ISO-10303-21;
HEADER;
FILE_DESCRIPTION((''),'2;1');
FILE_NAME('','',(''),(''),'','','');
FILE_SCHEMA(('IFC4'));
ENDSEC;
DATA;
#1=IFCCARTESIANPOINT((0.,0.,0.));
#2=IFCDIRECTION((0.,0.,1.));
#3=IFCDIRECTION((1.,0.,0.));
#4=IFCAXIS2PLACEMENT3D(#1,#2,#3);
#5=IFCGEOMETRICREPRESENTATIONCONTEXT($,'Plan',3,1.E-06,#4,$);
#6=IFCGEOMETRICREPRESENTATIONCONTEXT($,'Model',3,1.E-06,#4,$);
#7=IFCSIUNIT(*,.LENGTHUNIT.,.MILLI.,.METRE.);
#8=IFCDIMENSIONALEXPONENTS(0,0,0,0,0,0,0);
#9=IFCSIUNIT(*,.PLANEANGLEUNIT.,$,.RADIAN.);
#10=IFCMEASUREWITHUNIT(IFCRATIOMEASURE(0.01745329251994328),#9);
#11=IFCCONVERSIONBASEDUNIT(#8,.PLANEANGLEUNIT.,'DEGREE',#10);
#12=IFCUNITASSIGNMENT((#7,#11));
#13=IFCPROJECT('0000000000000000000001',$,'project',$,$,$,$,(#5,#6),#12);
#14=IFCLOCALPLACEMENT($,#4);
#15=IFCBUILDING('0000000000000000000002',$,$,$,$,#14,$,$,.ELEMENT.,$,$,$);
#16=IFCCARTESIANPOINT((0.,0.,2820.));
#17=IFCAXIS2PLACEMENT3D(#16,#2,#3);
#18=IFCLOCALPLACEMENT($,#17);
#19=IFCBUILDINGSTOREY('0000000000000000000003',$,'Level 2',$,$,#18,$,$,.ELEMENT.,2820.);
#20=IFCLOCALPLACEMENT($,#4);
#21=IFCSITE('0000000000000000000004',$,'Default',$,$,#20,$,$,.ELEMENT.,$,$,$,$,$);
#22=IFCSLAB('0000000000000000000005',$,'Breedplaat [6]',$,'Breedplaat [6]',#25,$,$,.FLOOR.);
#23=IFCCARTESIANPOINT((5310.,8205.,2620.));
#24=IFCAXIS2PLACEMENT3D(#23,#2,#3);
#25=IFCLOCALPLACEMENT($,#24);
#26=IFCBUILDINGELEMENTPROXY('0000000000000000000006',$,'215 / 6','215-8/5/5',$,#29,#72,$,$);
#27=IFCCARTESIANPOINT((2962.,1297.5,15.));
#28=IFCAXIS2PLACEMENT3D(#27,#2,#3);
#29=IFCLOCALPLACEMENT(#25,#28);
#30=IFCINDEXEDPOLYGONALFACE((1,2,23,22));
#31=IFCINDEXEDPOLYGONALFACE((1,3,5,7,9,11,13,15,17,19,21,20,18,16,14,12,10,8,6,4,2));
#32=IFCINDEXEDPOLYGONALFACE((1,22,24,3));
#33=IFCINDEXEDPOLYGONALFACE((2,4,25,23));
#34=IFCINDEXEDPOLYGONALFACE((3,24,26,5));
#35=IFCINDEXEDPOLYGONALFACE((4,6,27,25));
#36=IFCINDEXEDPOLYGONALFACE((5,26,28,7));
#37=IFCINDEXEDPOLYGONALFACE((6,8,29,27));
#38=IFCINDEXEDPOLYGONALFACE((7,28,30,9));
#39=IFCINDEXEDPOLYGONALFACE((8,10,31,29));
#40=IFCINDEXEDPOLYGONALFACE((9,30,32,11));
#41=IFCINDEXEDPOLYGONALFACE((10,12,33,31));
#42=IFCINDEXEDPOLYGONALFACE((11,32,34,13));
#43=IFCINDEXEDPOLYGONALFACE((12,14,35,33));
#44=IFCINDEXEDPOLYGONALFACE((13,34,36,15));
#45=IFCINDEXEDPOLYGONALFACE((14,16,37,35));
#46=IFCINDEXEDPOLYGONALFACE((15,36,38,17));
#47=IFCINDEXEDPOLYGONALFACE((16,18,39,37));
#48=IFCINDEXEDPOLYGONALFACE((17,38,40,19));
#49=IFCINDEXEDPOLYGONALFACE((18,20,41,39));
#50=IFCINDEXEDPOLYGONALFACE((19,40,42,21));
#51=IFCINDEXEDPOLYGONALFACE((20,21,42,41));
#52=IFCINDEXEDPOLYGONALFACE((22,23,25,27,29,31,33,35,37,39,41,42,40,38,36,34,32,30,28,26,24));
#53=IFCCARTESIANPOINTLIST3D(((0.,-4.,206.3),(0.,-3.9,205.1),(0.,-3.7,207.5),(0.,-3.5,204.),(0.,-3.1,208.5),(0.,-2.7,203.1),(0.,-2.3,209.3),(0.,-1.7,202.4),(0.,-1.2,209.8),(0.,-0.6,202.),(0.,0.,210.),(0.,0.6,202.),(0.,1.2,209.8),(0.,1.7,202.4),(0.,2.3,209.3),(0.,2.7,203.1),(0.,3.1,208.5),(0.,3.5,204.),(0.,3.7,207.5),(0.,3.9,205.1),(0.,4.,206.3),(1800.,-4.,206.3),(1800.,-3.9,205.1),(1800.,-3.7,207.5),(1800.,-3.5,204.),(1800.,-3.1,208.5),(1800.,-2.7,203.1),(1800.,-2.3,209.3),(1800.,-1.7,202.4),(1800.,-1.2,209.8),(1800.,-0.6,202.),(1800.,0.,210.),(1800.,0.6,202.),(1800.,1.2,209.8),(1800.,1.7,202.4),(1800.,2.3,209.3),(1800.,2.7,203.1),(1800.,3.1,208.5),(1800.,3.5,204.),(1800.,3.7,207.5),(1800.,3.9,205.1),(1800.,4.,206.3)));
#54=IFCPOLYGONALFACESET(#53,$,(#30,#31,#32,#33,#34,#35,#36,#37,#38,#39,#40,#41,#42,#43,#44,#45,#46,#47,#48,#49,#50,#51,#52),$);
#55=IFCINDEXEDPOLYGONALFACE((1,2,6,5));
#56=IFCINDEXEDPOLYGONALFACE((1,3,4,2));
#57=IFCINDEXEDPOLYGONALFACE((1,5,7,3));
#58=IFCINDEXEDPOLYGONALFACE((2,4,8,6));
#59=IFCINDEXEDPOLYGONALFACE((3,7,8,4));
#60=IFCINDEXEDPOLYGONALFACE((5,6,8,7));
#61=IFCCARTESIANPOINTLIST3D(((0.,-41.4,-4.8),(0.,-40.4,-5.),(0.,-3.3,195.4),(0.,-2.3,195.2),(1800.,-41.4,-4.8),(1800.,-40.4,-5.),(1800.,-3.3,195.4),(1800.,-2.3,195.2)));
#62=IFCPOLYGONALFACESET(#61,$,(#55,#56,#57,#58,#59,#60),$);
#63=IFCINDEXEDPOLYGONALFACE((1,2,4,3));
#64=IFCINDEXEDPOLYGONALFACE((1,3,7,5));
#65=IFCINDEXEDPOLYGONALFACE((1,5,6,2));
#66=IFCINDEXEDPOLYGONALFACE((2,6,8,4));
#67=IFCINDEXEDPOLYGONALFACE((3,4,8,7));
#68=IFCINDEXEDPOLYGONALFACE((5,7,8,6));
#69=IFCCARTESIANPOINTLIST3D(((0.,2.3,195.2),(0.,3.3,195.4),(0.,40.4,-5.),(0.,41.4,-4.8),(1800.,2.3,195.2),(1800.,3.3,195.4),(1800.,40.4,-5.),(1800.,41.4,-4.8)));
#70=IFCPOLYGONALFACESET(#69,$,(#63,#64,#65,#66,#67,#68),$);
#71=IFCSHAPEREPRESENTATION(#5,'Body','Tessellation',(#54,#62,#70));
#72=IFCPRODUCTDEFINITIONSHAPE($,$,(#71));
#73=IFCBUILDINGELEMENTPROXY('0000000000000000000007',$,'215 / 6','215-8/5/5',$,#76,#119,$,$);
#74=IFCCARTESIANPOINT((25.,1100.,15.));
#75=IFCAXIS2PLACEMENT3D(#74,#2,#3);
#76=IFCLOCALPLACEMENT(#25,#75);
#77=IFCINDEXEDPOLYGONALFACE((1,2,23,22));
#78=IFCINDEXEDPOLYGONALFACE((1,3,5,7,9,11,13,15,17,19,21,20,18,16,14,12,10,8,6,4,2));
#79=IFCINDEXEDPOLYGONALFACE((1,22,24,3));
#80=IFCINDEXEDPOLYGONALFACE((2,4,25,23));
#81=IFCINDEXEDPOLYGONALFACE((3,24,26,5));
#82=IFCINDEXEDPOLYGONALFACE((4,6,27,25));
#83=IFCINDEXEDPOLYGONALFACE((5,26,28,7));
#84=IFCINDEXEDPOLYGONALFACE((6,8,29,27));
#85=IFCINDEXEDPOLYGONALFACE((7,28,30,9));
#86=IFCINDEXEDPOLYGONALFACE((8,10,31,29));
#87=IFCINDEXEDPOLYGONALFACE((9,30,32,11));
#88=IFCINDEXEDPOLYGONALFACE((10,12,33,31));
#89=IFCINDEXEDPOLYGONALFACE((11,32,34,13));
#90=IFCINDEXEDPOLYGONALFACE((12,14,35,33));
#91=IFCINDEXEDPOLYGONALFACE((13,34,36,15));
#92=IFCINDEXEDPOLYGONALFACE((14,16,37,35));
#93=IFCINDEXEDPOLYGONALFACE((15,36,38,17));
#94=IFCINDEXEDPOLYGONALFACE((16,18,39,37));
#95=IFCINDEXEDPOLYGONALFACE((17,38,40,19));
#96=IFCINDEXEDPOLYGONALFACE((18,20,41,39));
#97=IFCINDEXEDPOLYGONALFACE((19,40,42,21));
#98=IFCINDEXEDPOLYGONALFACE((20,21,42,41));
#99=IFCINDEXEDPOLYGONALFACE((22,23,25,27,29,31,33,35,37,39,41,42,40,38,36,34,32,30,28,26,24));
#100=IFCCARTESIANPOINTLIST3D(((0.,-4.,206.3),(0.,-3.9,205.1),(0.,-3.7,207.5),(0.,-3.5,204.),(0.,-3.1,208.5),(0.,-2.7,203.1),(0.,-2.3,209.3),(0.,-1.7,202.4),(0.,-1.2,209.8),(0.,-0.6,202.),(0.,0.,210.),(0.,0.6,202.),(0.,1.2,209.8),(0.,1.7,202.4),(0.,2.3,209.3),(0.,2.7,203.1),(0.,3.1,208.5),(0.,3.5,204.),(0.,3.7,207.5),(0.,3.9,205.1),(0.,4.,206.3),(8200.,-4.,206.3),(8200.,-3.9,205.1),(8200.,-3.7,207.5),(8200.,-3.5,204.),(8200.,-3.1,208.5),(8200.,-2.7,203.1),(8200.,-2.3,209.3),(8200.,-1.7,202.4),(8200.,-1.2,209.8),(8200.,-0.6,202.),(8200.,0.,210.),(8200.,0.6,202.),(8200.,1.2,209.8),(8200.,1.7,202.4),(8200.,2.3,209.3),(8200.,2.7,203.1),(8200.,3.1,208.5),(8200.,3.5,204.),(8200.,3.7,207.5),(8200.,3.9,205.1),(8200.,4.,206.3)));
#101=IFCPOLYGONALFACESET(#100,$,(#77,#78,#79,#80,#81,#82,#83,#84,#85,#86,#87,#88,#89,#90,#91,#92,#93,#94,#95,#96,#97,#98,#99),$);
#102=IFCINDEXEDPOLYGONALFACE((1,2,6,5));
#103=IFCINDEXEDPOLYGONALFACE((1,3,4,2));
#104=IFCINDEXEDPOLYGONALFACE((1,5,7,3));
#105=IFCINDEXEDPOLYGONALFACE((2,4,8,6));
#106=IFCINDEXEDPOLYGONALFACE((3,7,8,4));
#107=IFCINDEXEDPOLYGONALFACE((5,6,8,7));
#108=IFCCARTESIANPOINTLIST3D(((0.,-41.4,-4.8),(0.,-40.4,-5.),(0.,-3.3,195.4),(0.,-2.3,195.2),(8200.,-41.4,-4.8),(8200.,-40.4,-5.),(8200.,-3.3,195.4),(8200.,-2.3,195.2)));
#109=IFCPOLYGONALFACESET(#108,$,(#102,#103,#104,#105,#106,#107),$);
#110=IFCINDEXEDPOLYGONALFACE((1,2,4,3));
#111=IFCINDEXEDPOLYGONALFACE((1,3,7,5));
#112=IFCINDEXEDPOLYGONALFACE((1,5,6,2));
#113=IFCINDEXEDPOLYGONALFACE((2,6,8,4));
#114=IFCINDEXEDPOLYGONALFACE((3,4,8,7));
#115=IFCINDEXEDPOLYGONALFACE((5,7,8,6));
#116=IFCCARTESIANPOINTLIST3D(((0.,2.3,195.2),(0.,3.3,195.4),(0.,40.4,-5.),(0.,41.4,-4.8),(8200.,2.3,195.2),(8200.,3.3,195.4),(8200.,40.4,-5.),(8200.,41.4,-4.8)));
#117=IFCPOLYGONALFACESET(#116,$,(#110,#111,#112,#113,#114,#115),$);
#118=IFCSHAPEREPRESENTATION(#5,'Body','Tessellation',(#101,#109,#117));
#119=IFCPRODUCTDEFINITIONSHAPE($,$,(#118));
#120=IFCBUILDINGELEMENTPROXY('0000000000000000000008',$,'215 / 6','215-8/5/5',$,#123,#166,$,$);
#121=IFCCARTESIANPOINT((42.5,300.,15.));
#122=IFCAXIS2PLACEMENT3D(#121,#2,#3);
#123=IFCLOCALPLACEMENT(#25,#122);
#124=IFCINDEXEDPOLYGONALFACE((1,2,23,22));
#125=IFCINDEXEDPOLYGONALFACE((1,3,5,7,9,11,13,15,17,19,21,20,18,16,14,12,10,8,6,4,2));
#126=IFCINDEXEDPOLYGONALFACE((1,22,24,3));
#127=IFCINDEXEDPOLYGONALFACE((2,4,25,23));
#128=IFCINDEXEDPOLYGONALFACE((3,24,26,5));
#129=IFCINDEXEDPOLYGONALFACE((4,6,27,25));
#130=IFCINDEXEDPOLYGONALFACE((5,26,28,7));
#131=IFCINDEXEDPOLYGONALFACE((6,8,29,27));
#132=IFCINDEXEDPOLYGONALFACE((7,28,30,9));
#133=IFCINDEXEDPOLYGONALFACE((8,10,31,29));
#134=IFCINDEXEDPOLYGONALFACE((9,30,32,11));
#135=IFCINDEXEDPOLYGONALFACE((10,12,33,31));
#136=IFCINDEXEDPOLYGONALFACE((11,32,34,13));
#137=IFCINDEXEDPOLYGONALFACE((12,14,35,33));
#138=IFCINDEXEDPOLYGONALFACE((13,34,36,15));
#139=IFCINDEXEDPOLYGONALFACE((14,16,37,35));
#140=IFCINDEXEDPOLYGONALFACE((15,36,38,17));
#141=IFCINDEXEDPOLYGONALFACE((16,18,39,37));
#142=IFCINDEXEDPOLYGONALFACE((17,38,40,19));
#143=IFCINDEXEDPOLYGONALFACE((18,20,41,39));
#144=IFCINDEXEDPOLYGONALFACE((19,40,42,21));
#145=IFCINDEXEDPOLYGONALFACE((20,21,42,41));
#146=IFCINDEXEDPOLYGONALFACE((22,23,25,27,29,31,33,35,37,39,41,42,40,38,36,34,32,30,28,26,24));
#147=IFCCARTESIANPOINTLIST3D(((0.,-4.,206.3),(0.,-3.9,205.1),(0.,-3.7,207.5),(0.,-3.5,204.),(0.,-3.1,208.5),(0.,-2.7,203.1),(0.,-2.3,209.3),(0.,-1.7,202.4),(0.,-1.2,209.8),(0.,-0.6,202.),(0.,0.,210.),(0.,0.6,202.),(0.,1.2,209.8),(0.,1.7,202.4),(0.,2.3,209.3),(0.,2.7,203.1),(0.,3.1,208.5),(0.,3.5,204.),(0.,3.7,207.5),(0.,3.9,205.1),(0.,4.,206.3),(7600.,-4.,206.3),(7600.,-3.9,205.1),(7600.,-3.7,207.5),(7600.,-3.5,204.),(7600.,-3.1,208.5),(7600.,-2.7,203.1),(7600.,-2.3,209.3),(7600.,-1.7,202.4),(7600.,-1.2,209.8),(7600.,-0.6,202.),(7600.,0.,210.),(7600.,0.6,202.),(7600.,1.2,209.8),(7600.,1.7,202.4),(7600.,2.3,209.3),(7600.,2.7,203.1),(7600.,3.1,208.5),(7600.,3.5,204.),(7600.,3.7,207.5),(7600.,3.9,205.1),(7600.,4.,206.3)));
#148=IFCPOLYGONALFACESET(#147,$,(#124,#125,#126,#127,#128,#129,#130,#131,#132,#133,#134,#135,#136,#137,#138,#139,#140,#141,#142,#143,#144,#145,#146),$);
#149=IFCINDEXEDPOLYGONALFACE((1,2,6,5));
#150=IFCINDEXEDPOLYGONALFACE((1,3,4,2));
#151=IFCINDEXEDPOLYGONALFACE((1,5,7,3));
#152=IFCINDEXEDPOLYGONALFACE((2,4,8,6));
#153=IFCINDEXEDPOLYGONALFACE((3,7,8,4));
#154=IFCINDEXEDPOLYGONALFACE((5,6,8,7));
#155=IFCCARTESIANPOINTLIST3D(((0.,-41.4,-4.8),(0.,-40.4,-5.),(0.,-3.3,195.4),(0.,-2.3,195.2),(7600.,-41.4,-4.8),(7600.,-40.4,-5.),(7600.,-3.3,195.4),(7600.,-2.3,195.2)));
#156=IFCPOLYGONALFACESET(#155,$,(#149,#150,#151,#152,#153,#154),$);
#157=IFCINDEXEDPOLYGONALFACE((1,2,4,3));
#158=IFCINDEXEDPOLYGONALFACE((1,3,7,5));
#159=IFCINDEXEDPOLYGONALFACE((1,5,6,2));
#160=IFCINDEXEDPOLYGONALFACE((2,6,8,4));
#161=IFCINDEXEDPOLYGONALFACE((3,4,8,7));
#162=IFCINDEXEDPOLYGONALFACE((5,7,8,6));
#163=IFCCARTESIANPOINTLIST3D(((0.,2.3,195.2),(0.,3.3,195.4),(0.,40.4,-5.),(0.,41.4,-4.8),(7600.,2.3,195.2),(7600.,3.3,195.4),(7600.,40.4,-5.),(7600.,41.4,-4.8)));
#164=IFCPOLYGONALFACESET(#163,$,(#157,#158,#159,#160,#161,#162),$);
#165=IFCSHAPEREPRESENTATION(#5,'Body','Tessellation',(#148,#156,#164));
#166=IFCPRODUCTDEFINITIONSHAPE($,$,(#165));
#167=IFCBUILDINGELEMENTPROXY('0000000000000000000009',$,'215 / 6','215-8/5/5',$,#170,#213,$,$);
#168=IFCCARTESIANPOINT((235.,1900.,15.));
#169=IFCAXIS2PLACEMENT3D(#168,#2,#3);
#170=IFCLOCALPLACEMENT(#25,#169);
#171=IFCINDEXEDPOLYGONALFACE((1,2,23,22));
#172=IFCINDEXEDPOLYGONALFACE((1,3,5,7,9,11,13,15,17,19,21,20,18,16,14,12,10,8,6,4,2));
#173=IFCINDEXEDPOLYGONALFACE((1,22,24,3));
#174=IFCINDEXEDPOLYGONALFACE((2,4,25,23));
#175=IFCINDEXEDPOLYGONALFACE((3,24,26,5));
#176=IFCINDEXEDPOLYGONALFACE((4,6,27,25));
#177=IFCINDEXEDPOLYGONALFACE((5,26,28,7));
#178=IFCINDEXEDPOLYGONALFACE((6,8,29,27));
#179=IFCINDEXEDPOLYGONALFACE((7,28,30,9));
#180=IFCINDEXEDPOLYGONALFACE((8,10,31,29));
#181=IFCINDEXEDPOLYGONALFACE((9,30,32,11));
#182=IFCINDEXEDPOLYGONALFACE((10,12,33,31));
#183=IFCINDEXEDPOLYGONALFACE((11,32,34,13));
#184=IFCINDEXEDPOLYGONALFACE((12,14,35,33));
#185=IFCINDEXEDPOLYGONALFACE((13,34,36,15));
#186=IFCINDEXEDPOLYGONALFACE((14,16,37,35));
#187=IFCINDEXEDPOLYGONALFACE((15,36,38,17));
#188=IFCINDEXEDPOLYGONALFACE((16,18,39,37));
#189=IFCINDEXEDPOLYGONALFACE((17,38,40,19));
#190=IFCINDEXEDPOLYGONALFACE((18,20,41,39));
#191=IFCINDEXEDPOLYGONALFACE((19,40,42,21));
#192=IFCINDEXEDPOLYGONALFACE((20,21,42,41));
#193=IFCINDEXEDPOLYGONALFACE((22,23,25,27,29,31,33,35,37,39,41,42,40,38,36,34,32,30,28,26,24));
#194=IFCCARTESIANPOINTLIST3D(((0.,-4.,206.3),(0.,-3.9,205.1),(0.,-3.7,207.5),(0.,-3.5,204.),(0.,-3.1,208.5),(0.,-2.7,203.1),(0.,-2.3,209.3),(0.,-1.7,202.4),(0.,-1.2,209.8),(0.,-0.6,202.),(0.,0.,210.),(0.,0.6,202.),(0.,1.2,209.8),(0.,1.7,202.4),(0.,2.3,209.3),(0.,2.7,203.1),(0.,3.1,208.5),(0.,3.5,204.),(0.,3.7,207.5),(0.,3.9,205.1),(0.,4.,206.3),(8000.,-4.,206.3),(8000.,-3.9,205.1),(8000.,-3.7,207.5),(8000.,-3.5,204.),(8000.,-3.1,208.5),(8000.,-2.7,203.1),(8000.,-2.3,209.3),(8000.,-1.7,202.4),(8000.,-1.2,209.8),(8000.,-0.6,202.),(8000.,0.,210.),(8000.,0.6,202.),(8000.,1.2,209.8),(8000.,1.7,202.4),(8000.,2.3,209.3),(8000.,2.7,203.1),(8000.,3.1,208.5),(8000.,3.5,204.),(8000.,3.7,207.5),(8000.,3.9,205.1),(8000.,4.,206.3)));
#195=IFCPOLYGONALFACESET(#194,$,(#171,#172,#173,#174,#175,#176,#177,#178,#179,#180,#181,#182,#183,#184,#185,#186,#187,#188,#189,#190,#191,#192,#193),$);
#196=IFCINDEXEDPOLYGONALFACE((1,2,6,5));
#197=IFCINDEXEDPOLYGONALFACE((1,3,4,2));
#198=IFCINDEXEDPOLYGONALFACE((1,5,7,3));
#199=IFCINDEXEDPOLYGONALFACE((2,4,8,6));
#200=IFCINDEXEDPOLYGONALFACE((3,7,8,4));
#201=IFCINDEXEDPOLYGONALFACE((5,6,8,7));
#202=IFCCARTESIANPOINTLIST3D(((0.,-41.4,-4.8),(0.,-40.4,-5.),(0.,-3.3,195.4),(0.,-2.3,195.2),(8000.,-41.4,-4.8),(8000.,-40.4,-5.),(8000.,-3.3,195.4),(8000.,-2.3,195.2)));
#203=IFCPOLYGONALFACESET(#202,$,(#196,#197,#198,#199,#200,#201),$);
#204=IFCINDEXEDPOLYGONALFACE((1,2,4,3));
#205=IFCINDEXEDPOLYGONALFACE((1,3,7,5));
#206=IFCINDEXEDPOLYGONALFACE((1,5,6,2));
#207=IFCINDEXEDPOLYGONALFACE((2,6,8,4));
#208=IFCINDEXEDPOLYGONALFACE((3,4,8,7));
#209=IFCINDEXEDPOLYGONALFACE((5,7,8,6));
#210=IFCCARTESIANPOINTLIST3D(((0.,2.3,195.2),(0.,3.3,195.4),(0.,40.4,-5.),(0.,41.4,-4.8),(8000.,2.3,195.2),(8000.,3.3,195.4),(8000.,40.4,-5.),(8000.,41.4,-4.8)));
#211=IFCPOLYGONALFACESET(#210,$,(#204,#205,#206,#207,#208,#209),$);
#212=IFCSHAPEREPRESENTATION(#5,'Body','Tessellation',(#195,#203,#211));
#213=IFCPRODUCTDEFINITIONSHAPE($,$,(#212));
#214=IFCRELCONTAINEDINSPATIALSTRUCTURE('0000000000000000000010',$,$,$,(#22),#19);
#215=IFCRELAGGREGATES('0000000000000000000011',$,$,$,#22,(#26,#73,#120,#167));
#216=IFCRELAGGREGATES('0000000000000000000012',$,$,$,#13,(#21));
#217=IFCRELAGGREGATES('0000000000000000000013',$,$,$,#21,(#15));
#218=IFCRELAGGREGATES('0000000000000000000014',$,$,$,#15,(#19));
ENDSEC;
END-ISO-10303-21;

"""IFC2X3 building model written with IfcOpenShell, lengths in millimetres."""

from ifc_helpers import new_model, entity, si_unit, converted_unit, frame, origin_with_axes, origin_2d_with_axis, place, context, project, spatial, rectangle, circle, extrude, element, aggregate, save


model = new_model("IFC2X3")

# Units and contexts
plan_context = context("Plan", 3, precision=1e-06, world=origin_with_axes())
model_context = context("Model", 3, precision=1e-06, world=origin_with_axes())
ifc_project = project(units=[si_unit("LENGTHUNIT", "METRE", prefix="MILLI"), converted_unit("PLANEANGLEUNIT", "DEGREE", entity("IfcRatioMeasure", 0.01745329251994328), si_unit("PLANEANGLEUNIT", "RADIAN"), dimensions=[0, 0, 0, 0, 0, 0, 0])], contexts=[plan_context, model_context])

# Site, building, storey
site_placement = place(None, origin_with_axes())
site = spatial("IfcSite", under=ifc_project, at=site_placement, Name="Default", CompositionType="ELEMENT")
building_placement = place(None, origin_with_axes())
building = spatial("IfcBuilding", under=site, at=building_placement, CompositionType="ELEMENT")
storey_placement = place(None, frame((0.0, 0.0, 2820.0), z_axis=(0.0, 0.0, 1.0), x_axis=(1.0, 0.0, 0.0)))
storey = spatial("IfcBuildingStorey", under=building, at=storey_placement, Name="Level 2", CompositionType="ELEMENT", Elevation=2820.0)

# Slab, building element proxies
slab_1_placement = place(None, frame((5310.0, 8205.0, 2620.0), z_axis=(0.0, 0.0, 1.0), x_axis=(1.0, 0.0, 0.0)))
slab_1 = element("IfcSlab", 1, at=slab_1_placement, inside=storey, Name="Breedplaat [6]", ObjectType="Breedplaat [6]", PredefinedType="FLOOR")
proxy_1_placement = place(slab_1_placement, frame((2962.0, 1297.5, 15.0), z_axis=(0.0, 0.0, 1.0), x_axis=(1.0, 0.0, 0.0)))
proxy_1 = element("IfcBuildingElementProxy", 2, at=proxy_1_placement, Name="215 / 6", Description="215-8/5/5", context=plan_context, shape_type="SweptSolid", body=[
    extrude(circle(Radius=4.0, at=origin_2d_with_axis()), frame((0.0, 0.0, 206.0), z_axis=(1.0, 0.0, 0.0), x_axis=(0.0, 0.0, 1.0)), (0.0, 0.0, 1.0), 1800.0),
    extrude(rectangle(XDim=203.8, YDim=1.0, at=origin_2d_with_axis()), frame((0.0, -21.9, 95.2), z_axis=(1.0, 0.0, 0.0), x_axis=(0.0, 0.187112, 0.982339)), (0.0, 0.0, 1.0), 1800.0),
    extrude(rectangle(XDim=203.8, YDim=1.0, at=origin_2d_with_axis()), frame((0.0, 21.9, 95.2), z_axis=(1.0, 0.0, 0.0), x_axis=(0.0, -0.187112, 0.982339)), (0.0, 0.0, 1.0), 1800.0),
])
proxy_2_placement = place(slab_1_placement, frame((25.0, 1100.0, 15.0), z_axis=(0.0, 0.0, 1.0), x_axis=(1.0, 0.0, 0.0)))
proxy_2 = element("IfcBuildingElementProxy", 3, at=proxy_2_placement, Name="215 / 6", Description="215-8/5/5", context=plan_context, shape_type="SweptSolid", body=[
    extrude(circle(Radius=4.0, at=origin_2d_with_axis()), frame((0.0, 0.0, 206.0), z_axis=(1.0, 0.0, 0.0), x_axis=(0.0, 0.0, 1.0)), (0.0, 0.0, 1.0), 8200.0),
    extrude(rectangle(XDim=203.8, YDim=1.0, at=origin_2d_with_axis()), frame((0.0, -21.9, 95.2), z_axis=(1.0, 0.0, 0.0), x_axis=(0.0, 0.187112, 0.982339)), (0.0, 0.0, 1.0), 8200.0),
    extrude(rectangle(XDim=203.8, YDim=1.0, at=origin_2d_with_axis()), frame((0.0, 21.9, 95.2), z_axis=(1.0, 0.0, 0.0), x_axis=(0.0, -0.187112, 0.982339)), (0.0, 0.0, 1.0), 8200.0),
])
proxy_3_placement = place(slab_1_placement, frame((42.5, 300.0, 15.0), z_axis=(0.0, 0.0, 1.0), x_axis=(1.0, 0.0, 0.0)))
proxy_3 = element("IfcBuildingElementProxy", 4, at=proxy_3_placement, Name="215 / 6", Description="215-8/5/5", context=plan_context, shape_type="SweptSolid", body=[
    extrude(circle(Radius=4.0, at=origin_2d_with_axis()), frame((0.0, 0.0, 206.0), z_axis=(1.0, 0.0, 0.0), x_axis=(0.0, 0.0, 1.0)), (0.0, 0.0, 1.0), 7600.0),
    extrude(rectangle(XDim=203.8, YDim=1.0, at=origin_2d_with_axis()), frame((0.0, -21.9, 95.2), z_axis=(1.0, 0.0, 0.0), x_axis=(0.0, 0.187112, 0.982339)), (0.0, 0.0, 1.0), 7600.0),
    extrude(rectangle(XDim=203.8, YDim=1.0, at=origin_2d_with_axis()), frame((0.0, 21.9, 95.2), z_axis=(1.0, 0.0, 0.0), x_axis=(0.0, -0.187112, 0.982339)), (0.0, 0.0, 1.0), 7600.0),
])
proxy_4_placement = place(slab_1_placement, frame((235.0, 1900.0, 15.0), z_axis=(0.0, 0.0, 1.0), x_axis=(1.0, 0.0, 0.0)))
proxy_4 = element("IfcBuildingElementProxy", 5, at=proxy_4_placement, Name="215 / 6", Description="215-8/5/5", context=plan_context, shape_type="SweptSolid", body=[
    extrude(circle(Radius=4.0, at=origin_2d_with_axis()), frame((0.0, 0.0, 206.0), z_axis=(1.0, 0.0, 0.0), x_axis=(0.0, 0.0, 1.0)), (0.0, 0.0, 1.0), 8000.0),
    extrude(rectangle(XDim=203.8, YDim=1.0, at=origin_2d_with_axis()), frame((0.0, -21.9, 95.2), z_axis=(1.0, 0.0, 0.0), x_axis=(0.0, 0.187112, 0.982339)), (0.0, 0.0, 1.0), 8000.0),
    extrude(rectangle(XDim=203.8, YDim=1.0, at=origin_2d_with_axis()), frame((0.0, 21.9, 95.2), z_axis=(1.0, 0.0, 0.0), x_axis=(0.0, -0.187112, 0.982339)), (0.0, 0.0, 1.0), 8000.0),
])
aggregate(slab_1, [proxy_1, proxy_2, proxy_3, proxy_4])

save(model, "model.ifc")
